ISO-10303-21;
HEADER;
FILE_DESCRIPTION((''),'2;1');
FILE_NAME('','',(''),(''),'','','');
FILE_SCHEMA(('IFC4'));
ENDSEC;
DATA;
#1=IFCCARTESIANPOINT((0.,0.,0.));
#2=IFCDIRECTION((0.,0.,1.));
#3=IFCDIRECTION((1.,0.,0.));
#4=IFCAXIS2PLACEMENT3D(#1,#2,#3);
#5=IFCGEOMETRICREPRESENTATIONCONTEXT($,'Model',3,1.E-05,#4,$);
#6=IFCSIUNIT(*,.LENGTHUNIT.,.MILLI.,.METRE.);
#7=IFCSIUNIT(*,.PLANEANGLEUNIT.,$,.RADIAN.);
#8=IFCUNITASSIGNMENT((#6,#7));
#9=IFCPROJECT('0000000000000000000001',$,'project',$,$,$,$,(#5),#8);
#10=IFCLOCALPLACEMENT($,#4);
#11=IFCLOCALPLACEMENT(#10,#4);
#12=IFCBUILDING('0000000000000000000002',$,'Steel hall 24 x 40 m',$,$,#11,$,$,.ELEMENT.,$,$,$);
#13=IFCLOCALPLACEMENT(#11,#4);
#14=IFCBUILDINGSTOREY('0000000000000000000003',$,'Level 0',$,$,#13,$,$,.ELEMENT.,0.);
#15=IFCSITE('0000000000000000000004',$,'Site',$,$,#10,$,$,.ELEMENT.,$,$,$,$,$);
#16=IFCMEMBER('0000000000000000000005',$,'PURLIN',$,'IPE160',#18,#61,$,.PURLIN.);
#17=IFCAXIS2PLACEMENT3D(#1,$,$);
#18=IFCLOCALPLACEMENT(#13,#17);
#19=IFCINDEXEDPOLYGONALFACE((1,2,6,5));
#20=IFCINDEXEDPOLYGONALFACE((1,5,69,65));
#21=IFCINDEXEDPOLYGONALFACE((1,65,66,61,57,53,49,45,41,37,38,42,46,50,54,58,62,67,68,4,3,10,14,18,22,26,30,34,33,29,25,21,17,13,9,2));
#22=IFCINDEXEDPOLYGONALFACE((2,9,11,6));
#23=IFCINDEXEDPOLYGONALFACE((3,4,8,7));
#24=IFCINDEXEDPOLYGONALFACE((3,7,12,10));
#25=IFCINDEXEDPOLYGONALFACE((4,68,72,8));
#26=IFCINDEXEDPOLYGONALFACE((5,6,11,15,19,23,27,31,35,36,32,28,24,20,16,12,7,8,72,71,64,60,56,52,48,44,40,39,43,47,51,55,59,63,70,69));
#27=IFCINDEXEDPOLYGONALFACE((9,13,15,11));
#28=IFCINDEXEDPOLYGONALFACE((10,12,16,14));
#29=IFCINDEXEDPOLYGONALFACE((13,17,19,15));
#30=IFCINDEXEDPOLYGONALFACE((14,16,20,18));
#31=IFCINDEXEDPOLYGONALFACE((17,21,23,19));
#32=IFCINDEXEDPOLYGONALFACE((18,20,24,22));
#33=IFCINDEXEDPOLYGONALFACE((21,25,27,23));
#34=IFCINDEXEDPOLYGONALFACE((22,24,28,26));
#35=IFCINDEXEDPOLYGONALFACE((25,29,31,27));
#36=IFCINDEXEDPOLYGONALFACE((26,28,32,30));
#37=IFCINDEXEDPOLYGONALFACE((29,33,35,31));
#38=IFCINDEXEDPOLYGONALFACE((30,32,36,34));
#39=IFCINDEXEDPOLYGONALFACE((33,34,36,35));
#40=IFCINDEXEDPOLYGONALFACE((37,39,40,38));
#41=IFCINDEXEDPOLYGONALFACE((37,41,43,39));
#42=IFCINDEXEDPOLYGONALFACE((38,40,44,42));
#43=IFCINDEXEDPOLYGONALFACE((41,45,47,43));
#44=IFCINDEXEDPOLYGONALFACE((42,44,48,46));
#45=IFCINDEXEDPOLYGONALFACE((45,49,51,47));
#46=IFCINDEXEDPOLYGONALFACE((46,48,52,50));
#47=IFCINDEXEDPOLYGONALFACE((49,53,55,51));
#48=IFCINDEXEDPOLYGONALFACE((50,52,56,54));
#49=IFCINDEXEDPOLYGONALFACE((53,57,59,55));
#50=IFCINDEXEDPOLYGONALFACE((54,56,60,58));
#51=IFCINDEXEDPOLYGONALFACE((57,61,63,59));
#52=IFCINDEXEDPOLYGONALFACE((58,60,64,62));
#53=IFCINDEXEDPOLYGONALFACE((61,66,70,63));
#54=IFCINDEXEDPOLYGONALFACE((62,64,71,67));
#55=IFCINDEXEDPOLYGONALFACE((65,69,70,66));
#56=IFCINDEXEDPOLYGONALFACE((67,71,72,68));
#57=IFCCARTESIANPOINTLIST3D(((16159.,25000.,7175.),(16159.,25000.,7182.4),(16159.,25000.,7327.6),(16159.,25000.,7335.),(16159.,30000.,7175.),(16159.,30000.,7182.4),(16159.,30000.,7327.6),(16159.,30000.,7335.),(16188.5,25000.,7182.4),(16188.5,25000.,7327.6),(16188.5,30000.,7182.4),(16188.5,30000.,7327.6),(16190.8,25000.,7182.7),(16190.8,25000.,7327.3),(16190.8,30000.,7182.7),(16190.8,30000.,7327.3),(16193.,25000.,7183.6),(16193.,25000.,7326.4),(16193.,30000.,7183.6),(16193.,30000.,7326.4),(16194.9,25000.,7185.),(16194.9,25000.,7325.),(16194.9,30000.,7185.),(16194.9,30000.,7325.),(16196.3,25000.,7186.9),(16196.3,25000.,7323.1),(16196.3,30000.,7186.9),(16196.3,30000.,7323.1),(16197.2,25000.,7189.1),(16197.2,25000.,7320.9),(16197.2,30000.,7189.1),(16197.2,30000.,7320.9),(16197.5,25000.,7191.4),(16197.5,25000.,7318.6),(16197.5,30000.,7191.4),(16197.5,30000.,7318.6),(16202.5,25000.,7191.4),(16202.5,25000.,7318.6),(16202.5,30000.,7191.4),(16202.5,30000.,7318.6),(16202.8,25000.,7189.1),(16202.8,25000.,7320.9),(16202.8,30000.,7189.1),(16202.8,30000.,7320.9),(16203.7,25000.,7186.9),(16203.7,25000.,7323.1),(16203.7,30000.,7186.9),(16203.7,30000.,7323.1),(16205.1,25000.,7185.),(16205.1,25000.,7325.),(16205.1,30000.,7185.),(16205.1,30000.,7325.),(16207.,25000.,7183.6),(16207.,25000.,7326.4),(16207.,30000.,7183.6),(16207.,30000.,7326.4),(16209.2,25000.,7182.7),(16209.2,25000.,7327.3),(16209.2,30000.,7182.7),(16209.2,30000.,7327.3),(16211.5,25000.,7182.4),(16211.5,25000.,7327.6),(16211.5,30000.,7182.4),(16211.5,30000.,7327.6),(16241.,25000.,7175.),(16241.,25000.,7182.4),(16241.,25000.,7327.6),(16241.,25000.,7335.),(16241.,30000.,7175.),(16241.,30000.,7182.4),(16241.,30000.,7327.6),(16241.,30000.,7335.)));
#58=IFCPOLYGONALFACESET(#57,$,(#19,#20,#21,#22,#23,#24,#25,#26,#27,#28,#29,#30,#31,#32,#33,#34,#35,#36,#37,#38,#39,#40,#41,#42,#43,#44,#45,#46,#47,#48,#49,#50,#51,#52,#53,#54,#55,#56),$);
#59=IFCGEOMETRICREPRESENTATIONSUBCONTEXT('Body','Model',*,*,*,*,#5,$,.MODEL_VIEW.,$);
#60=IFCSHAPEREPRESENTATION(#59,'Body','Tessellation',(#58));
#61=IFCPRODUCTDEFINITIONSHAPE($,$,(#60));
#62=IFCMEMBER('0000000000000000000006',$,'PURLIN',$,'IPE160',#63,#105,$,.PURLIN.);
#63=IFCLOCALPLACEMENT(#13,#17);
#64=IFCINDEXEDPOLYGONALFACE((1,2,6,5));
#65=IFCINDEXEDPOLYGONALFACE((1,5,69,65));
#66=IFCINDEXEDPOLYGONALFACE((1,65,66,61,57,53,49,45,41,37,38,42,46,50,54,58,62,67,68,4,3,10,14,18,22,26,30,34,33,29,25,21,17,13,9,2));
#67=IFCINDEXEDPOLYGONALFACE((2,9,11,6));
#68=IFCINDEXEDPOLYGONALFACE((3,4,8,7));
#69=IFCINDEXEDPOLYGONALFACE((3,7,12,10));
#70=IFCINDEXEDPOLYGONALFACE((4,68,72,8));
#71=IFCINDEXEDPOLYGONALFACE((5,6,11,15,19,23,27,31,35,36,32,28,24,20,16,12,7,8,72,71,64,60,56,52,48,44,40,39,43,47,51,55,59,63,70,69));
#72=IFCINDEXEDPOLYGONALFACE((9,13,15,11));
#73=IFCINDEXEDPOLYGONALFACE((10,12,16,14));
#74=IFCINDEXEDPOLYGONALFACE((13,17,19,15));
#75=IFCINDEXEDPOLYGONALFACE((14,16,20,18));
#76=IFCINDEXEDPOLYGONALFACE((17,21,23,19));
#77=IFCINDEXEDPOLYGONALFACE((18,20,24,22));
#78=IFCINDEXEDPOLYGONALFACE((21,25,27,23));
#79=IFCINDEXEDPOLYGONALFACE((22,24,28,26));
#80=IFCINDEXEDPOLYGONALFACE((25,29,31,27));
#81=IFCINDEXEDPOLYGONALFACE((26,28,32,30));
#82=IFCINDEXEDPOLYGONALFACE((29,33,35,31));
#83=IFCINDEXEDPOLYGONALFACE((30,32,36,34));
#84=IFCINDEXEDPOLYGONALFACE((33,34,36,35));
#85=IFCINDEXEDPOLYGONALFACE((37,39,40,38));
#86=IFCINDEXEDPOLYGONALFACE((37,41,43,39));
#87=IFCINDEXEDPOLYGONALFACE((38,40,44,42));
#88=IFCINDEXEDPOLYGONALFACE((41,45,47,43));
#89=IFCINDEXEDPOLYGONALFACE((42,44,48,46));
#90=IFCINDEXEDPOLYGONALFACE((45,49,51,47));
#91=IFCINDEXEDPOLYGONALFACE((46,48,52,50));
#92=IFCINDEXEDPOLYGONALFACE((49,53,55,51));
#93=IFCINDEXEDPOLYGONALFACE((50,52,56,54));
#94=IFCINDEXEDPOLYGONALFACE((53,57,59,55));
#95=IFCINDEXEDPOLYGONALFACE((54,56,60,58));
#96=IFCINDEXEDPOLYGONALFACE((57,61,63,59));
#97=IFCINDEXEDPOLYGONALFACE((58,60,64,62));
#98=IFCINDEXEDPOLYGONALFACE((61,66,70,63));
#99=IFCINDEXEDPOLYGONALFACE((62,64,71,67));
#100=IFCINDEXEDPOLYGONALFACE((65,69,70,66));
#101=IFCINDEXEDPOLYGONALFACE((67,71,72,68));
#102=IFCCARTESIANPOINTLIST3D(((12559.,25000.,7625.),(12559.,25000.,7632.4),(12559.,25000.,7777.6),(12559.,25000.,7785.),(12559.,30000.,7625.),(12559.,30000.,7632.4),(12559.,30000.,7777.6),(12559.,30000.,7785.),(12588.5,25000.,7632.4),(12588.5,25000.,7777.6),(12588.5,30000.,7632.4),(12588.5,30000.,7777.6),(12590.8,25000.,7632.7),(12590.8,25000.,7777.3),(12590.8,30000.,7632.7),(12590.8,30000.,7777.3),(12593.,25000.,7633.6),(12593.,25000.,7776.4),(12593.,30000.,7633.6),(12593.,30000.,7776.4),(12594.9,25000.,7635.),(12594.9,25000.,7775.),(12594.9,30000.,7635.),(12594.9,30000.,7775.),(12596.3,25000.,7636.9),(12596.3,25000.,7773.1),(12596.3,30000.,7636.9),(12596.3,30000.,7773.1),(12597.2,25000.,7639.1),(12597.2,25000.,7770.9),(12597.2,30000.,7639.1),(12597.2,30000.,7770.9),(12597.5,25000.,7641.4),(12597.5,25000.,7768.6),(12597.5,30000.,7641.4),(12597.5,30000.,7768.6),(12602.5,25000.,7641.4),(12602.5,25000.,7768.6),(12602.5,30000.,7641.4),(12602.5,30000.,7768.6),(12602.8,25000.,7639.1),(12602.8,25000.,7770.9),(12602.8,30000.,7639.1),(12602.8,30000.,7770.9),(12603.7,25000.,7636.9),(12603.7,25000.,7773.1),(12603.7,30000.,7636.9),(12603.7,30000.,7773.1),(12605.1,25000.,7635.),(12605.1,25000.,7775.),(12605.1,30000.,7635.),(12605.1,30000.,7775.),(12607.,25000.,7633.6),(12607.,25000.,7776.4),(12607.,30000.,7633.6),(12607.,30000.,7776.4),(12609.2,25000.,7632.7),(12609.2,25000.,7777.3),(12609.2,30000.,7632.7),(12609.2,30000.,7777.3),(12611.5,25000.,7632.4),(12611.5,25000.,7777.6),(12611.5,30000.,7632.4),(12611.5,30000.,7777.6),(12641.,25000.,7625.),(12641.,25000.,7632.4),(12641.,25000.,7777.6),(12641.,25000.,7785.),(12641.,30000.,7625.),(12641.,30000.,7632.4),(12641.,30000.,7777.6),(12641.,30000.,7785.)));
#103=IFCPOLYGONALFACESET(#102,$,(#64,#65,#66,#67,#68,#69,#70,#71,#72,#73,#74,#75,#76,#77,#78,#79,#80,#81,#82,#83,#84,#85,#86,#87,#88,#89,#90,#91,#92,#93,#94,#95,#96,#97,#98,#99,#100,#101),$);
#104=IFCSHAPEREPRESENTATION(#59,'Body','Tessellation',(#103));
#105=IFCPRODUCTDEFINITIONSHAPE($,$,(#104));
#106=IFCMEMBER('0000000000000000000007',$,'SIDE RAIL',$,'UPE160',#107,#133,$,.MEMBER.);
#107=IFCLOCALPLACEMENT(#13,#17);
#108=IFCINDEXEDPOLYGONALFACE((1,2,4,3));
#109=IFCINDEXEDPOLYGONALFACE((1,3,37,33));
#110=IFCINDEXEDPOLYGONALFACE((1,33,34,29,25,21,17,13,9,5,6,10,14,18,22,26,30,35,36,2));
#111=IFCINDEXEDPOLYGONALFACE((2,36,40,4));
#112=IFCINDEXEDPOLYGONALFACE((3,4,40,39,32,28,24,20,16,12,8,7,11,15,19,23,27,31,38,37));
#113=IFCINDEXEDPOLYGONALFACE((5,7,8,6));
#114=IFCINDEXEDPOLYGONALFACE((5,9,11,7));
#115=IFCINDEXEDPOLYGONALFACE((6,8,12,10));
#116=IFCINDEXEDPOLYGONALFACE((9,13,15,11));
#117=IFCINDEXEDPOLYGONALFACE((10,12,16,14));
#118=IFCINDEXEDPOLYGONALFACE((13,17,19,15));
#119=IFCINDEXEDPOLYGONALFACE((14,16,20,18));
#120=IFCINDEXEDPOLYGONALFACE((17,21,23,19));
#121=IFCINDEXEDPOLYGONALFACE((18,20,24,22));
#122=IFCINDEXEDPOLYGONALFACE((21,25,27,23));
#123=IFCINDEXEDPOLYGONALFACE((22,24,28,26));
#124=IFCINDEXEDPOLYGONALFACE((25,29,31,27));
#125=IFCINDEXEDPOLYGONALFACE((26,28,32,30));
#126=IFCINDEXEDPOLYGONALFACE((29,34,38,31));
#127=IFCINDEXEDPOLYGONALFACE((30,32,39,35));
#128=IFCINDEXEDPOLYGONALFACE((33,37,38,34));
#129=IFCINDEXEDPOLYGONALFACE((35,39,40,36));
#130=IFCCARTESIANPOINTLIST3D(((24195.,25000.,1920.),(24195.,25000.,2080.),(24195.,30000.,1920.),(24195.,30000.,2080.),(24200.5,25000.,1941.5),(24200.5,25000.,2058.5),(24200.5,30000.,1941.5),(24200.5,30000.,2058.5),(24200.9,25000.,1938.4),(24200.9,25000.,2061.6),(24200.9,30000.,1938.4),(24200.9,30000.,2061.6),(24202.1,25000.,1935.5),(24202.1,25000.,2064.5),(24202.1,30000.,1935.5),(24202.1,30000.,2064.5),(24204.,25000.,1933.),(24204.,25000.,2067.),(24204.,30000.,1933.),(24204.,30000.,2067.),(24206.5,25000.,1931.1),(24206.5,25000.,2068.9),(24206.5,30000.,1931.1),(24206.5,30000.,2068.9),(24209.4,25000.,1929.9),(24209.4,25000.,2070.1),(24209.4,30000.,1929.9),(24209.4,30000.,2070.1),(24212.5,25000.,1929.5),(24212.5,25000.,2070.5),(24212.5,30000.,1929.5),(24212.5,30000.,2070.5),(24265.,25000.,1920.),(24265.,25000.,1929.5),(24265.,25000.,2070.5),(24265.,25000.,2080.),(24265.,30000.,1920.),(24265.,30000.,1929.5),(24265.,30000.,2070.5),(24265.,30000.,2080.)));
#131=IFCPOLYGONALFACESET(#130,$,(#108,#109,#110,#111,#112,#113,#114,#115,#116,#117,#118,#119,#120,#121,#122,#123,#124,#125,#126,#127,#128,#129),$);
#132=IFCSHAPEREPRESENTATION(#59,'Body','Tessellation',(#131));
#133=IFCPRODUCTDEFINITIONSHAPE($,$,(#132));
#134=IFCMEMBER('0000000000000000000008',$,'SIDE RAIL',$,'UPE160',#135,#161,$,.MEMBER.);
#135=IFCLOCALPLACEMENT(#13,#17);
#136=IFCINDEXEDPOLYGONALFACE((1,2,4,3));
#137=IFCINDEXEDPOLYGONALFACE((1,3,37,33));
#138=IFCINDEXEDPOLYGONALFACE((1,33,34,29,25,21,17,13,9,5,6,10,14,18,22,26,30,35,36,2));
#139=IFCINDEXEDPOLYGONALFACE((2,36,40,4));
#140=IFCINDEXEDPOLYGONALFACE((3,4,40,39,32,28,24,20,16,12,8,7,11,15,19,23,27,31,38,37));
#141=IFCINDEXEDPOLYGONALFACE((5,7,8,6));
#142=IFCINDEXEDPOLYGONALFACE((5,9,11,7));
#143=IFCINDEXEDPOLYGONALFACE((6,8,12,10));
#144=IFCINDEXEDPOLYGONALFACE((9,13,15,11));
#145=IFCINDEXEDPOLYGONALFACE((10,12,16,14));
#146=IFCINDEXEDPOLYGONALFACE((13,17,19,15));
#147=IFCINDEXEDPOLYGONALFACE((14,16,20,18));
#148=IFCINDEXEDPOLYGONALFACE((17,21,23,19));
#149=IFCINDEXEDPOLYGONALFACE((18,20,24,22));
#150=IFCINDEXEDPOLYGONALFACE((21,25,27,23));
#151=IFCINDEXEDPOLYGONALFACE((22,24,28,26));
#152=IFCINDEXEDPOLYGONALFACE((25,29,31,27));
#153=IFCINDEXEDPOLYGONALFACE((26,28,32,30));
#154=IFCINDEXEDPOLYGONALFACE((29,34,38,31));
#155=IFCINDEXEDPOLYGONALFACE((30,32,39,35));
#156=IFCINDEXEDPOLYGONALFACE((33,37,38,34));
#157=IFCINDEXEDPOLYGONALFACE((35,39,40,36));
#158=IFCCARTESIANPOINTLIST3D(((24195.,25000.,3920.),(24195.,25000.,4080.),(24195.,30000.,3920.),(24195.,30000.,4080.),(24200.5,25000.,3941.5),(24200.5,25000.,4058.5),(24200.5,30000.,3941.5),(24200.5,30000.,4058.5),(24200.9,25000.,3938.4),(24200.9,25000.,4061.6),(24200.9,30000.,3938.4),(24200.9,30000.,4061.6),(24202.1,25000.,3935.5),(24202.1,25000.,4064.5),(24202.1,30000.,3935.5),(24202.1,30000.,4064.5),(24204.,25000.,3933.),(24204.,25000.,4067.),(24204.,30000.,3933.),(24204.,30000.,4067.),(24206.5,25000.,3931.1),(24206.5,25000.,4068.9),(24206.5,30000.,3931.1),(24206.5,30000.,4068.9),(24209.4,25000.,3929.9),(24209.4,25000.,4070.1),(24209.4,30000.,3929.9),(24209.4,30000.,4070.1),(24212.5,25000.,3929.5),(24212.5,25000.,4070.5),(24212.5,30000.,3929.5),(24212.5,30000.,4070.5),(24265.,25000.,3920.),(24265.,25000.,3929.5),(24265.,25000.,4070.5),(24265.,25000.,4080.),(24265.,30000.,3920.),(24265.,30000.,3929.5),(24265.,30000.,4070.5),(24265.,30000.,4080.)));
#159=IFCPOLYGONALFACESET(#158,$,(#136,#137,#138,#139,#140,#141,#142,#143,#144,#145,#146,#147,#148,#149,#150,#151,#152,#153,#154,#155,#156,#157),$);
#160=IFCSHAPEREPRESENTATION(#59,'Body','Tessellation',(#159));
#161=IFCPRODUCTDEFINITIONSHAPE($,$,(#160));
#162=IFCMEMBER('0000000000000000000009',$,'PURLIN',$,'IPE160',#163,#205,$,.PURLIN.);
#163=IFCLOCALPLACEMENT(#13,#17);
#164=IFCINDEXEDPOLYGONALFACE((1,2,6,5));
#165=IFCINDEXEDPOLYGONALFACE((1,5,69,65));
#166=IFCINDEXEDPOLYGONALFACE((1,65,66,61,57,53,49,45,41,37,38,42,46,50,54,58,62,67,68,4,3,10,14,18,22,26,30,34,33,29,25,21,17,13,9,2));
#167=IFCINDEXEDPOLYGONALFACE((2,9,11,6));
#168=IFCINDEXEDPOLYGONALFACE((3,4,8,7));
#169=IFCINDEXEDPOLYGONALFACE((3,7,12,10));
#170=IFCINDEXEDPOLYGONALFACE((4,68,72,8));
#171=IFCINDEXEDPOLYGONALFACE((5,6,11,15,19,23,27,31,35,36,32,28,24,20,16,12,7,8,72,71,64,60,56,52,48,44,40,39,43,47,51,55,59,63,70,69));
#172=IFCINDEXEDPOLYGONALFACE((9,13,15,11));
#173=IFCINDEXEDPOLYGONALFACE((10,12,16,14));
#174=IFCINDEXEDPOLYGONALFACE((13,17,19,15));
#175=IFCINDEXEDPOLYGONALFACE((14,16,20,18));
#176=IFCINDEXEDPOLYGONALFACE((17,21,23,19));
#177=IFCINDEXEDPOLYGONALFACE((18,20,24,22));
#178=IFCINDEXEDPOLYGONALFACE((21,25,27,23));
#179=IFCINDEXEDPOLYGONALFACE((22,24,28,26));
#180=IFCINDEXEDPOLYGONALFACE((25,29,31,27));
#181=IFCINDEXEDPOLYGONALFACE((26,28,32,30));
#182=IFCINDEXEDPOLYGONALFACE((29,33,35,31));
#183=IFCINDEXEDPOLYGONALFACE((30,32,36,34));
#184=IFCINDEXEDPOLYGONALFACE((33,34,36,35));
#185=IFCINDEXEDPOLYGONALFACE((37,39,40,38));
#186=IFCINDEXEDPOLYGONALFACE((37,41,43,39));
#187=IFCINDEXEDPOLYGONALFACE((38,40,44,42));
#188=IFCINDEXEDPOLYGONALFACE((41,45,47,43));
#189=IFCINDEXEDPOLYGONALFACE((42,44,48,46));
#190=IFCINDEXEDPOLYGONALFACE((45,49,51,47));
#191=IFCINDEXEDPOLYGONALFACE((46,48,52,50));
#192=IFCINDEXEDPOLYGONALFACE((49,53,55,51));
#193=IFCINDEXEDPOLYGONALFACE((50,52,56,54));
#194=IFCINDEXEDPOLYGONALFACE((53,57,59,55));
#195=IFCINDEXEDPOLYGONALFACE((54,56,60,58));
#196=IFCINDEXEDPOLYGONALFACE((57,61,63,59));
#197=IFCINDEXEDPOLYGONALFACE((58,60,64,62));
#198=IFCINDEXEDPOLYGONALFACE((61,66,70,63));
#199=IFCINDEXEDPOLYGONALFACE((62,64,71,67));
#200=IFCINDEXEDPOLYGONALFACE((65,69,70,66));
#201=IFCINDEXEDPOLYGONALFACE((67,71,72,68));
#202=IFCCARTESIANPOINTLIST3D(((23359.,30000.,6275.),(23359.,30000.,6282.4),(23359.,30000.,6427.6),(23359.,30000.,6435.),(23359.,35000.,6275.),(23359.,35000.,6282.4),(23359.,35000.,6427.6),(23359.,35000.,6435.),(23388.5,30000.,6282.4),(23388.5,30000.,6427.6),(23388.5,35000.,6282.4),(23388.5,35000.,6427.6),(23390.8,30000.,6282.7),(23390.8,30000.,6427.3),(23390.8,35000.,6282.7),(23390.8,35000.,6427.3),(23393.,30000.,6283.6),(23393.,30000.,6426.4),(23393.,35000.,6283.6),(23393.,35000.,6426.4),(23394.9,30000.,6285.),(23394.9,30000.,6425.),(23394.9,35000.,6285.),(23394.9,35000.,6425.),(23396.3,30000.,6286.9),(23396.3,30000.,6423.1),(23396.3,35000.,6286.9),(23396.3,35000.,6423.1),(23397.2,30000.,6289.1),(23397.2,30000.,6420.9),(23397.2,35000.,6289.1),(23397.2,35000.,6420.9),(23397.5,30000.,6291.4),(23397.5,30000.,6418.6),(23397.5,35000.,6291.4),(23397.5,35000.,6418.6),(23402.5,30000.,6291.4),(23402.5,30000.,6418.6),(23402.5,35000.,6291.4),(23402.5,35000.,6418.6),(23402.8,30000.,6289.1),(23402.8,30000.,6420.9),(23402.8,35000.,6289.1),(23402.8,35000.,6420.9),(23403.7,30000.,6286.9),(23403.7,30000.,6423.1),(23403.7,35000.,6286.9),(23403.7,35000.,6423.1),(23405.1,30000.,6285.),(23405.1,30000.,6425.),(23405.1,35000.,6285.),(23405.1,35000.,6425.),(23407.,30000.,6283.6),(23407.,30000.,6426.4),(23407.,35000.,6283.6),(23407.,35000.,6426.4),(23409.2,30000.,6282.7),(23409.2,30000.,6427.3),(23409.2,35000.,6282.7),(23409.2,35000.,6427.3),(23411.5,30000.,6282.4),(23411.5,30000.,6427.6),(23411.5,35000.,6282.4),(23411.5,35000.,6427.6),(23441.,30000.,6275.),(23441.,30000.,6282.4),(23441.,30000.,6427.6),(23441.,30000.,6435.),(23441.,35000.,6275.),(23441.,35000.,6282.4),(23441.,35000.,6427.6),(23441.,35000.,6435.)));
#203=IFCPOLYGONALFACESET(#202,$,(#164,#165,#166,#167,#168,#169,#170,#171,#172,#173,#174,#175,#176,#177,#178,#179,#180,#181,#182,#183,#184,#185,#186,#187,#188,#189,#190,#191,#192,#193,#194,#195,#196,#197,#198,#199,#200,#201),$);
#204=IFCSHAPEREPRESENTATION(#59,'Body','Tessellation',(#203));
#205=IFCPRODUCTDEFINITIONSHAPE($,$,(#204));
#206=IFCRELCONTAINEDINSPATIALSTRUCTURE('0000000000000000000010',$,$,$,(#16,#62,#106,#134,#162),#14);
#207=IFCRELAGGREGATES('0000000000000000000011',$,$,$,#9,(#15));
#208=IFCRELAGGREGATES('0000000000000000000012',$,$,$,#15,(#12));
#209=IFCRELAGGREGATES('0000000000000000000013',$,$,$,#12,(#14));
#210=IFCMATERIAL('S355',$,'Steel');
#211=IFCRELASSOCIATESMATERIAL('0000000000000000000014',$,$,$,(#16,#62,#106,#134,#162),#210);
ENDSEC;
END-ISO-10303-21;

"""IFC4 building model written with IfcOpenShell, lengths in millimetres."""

from ifc_helpers import new_model, si_unit, frame, origin_with_axes, place, context, subcontext, project, spatial, i_section, u_section, extrude, material, element, save


model = new_model("IFC4")

# Units and contexts
model_context = context("Model", 3, precision=1e-05, world=origin_with_axes())
body_context = subcontext(model_context, "Body", "Model", "MODEL_VIEW")
ifc_project = project(units=[si_unit("LENGTHUNIT", "METRE", prefix="MILLI"), si_unit("PLANEANGLEUNIT", "RADIAN")], contexts=[model_context])

# Site, building, storey
site_placement = place(None, origin_with_axes())
site = spatial("IfcSite", under=ifc_project, at=site_placement, Name="Site", CompositionType="ELEMENT")
building_placement = place(site_placement, origin_with_axes())
building = spatial("IfcBuilding", under=site, at=building_placement, Name="Steel hall 24 x 40 m", CompositionType="ELEMENT")
storey_placement = place(building_placement, origin_with_axes())
storey = spatial("IfcBuildingStorey", under=building, at=storey_placement, Name="Level 0", CompositionType="ELEMENT", Elevation=0.0)

# Shared definitions
ifc_material = material(Name="S355", Category="Steel")

# Members
for number, where, z_axis, x_axis, name in (
    (1, (16200.0, 25000.0, 7255.0), (0.0, 1.0, 0.0), (1.0, 0.0, 0.0), "PURLIN"),
    (2, (12600.0, 25000.0, 7705.0), (0.0, 1.0, 0.0), (1.0, 0.0, 0.0), "PURLIN"),
):
    element("IfcMember", number, at=place(storey_placement, frame(where, z_axis=z_axis, x_axis=x_axis)), inside=storey, material=ifc_material, Name=name, ObjectType="IPE160", PredefinedType="PURLIN", context=body_context, shape_type="SweptSolid", body=[
        extrude(i_section(OverallWidth=82.0, OverallDepth=160.0, WebThickness=5.0, FlangeThickness=7.4, FilletRadius=9.0), origin_with_axes(), (0.0, 0.0, 1.0), 5000.0),
    ])
for number, where, z_axis, x_axis, name in (
    (3, (24230.0, 25000.0, 2000.0), (0.0, 1.0, 0.0), (1.0, 0.0, 0.0), "SIDE RAIL"),
    (4, (24230.0, 25000.0, 4000.0), (0.0, 1.0, 0.0), (1.0, 0.0, 0.0), "SIDE RAIL"),
):
    element("IfcMember", number, at=place(storey_placement, frame(where, z_axis=z_axis, x_axis=x_axis)), inside=storey, material=ifc_material, Name=name, ObjectType="UPE160", PredefinedType="MEMBER", context=body_context, shape_type="SweptSolid", body=[
        extrude(u_section(Depth=160.0, FlangeWidth=70.0, WebThickness=5.5, FlangeThickness=9.5, FilletRadius=12.0), origin_with_axes(), (0.0, 0.0, 1.0), 5000.0),
    ])
for number, where, z_axis, x_axis, name in (
    (5, (23400.0, 30000.0, 6355.0), (0.0, 1.0, 0.0), (1.0, 0.0, 0.0), "PURLIN"),
):
    element("IfcMember", number, at=place(storey_placement, frame(where, z_axis=z_axis, x_axis=x_axis)), inside=storey, material=ifc_material, Name=name, ObjectType="IPE160", PredefinedType="PURLIN", context=body_context, shape_type="SweptSolid", body=[
        extrude(i_section(OverallWidth=82.0, OverallDepth=160.0, WebThickness=5.0, FlangeThickness=7.4, FilletRadius=9.0), origin_with_axes(), (0.0, 0.0, 1.0), 5000.0),
    ])

save(model, "model.ifc")
